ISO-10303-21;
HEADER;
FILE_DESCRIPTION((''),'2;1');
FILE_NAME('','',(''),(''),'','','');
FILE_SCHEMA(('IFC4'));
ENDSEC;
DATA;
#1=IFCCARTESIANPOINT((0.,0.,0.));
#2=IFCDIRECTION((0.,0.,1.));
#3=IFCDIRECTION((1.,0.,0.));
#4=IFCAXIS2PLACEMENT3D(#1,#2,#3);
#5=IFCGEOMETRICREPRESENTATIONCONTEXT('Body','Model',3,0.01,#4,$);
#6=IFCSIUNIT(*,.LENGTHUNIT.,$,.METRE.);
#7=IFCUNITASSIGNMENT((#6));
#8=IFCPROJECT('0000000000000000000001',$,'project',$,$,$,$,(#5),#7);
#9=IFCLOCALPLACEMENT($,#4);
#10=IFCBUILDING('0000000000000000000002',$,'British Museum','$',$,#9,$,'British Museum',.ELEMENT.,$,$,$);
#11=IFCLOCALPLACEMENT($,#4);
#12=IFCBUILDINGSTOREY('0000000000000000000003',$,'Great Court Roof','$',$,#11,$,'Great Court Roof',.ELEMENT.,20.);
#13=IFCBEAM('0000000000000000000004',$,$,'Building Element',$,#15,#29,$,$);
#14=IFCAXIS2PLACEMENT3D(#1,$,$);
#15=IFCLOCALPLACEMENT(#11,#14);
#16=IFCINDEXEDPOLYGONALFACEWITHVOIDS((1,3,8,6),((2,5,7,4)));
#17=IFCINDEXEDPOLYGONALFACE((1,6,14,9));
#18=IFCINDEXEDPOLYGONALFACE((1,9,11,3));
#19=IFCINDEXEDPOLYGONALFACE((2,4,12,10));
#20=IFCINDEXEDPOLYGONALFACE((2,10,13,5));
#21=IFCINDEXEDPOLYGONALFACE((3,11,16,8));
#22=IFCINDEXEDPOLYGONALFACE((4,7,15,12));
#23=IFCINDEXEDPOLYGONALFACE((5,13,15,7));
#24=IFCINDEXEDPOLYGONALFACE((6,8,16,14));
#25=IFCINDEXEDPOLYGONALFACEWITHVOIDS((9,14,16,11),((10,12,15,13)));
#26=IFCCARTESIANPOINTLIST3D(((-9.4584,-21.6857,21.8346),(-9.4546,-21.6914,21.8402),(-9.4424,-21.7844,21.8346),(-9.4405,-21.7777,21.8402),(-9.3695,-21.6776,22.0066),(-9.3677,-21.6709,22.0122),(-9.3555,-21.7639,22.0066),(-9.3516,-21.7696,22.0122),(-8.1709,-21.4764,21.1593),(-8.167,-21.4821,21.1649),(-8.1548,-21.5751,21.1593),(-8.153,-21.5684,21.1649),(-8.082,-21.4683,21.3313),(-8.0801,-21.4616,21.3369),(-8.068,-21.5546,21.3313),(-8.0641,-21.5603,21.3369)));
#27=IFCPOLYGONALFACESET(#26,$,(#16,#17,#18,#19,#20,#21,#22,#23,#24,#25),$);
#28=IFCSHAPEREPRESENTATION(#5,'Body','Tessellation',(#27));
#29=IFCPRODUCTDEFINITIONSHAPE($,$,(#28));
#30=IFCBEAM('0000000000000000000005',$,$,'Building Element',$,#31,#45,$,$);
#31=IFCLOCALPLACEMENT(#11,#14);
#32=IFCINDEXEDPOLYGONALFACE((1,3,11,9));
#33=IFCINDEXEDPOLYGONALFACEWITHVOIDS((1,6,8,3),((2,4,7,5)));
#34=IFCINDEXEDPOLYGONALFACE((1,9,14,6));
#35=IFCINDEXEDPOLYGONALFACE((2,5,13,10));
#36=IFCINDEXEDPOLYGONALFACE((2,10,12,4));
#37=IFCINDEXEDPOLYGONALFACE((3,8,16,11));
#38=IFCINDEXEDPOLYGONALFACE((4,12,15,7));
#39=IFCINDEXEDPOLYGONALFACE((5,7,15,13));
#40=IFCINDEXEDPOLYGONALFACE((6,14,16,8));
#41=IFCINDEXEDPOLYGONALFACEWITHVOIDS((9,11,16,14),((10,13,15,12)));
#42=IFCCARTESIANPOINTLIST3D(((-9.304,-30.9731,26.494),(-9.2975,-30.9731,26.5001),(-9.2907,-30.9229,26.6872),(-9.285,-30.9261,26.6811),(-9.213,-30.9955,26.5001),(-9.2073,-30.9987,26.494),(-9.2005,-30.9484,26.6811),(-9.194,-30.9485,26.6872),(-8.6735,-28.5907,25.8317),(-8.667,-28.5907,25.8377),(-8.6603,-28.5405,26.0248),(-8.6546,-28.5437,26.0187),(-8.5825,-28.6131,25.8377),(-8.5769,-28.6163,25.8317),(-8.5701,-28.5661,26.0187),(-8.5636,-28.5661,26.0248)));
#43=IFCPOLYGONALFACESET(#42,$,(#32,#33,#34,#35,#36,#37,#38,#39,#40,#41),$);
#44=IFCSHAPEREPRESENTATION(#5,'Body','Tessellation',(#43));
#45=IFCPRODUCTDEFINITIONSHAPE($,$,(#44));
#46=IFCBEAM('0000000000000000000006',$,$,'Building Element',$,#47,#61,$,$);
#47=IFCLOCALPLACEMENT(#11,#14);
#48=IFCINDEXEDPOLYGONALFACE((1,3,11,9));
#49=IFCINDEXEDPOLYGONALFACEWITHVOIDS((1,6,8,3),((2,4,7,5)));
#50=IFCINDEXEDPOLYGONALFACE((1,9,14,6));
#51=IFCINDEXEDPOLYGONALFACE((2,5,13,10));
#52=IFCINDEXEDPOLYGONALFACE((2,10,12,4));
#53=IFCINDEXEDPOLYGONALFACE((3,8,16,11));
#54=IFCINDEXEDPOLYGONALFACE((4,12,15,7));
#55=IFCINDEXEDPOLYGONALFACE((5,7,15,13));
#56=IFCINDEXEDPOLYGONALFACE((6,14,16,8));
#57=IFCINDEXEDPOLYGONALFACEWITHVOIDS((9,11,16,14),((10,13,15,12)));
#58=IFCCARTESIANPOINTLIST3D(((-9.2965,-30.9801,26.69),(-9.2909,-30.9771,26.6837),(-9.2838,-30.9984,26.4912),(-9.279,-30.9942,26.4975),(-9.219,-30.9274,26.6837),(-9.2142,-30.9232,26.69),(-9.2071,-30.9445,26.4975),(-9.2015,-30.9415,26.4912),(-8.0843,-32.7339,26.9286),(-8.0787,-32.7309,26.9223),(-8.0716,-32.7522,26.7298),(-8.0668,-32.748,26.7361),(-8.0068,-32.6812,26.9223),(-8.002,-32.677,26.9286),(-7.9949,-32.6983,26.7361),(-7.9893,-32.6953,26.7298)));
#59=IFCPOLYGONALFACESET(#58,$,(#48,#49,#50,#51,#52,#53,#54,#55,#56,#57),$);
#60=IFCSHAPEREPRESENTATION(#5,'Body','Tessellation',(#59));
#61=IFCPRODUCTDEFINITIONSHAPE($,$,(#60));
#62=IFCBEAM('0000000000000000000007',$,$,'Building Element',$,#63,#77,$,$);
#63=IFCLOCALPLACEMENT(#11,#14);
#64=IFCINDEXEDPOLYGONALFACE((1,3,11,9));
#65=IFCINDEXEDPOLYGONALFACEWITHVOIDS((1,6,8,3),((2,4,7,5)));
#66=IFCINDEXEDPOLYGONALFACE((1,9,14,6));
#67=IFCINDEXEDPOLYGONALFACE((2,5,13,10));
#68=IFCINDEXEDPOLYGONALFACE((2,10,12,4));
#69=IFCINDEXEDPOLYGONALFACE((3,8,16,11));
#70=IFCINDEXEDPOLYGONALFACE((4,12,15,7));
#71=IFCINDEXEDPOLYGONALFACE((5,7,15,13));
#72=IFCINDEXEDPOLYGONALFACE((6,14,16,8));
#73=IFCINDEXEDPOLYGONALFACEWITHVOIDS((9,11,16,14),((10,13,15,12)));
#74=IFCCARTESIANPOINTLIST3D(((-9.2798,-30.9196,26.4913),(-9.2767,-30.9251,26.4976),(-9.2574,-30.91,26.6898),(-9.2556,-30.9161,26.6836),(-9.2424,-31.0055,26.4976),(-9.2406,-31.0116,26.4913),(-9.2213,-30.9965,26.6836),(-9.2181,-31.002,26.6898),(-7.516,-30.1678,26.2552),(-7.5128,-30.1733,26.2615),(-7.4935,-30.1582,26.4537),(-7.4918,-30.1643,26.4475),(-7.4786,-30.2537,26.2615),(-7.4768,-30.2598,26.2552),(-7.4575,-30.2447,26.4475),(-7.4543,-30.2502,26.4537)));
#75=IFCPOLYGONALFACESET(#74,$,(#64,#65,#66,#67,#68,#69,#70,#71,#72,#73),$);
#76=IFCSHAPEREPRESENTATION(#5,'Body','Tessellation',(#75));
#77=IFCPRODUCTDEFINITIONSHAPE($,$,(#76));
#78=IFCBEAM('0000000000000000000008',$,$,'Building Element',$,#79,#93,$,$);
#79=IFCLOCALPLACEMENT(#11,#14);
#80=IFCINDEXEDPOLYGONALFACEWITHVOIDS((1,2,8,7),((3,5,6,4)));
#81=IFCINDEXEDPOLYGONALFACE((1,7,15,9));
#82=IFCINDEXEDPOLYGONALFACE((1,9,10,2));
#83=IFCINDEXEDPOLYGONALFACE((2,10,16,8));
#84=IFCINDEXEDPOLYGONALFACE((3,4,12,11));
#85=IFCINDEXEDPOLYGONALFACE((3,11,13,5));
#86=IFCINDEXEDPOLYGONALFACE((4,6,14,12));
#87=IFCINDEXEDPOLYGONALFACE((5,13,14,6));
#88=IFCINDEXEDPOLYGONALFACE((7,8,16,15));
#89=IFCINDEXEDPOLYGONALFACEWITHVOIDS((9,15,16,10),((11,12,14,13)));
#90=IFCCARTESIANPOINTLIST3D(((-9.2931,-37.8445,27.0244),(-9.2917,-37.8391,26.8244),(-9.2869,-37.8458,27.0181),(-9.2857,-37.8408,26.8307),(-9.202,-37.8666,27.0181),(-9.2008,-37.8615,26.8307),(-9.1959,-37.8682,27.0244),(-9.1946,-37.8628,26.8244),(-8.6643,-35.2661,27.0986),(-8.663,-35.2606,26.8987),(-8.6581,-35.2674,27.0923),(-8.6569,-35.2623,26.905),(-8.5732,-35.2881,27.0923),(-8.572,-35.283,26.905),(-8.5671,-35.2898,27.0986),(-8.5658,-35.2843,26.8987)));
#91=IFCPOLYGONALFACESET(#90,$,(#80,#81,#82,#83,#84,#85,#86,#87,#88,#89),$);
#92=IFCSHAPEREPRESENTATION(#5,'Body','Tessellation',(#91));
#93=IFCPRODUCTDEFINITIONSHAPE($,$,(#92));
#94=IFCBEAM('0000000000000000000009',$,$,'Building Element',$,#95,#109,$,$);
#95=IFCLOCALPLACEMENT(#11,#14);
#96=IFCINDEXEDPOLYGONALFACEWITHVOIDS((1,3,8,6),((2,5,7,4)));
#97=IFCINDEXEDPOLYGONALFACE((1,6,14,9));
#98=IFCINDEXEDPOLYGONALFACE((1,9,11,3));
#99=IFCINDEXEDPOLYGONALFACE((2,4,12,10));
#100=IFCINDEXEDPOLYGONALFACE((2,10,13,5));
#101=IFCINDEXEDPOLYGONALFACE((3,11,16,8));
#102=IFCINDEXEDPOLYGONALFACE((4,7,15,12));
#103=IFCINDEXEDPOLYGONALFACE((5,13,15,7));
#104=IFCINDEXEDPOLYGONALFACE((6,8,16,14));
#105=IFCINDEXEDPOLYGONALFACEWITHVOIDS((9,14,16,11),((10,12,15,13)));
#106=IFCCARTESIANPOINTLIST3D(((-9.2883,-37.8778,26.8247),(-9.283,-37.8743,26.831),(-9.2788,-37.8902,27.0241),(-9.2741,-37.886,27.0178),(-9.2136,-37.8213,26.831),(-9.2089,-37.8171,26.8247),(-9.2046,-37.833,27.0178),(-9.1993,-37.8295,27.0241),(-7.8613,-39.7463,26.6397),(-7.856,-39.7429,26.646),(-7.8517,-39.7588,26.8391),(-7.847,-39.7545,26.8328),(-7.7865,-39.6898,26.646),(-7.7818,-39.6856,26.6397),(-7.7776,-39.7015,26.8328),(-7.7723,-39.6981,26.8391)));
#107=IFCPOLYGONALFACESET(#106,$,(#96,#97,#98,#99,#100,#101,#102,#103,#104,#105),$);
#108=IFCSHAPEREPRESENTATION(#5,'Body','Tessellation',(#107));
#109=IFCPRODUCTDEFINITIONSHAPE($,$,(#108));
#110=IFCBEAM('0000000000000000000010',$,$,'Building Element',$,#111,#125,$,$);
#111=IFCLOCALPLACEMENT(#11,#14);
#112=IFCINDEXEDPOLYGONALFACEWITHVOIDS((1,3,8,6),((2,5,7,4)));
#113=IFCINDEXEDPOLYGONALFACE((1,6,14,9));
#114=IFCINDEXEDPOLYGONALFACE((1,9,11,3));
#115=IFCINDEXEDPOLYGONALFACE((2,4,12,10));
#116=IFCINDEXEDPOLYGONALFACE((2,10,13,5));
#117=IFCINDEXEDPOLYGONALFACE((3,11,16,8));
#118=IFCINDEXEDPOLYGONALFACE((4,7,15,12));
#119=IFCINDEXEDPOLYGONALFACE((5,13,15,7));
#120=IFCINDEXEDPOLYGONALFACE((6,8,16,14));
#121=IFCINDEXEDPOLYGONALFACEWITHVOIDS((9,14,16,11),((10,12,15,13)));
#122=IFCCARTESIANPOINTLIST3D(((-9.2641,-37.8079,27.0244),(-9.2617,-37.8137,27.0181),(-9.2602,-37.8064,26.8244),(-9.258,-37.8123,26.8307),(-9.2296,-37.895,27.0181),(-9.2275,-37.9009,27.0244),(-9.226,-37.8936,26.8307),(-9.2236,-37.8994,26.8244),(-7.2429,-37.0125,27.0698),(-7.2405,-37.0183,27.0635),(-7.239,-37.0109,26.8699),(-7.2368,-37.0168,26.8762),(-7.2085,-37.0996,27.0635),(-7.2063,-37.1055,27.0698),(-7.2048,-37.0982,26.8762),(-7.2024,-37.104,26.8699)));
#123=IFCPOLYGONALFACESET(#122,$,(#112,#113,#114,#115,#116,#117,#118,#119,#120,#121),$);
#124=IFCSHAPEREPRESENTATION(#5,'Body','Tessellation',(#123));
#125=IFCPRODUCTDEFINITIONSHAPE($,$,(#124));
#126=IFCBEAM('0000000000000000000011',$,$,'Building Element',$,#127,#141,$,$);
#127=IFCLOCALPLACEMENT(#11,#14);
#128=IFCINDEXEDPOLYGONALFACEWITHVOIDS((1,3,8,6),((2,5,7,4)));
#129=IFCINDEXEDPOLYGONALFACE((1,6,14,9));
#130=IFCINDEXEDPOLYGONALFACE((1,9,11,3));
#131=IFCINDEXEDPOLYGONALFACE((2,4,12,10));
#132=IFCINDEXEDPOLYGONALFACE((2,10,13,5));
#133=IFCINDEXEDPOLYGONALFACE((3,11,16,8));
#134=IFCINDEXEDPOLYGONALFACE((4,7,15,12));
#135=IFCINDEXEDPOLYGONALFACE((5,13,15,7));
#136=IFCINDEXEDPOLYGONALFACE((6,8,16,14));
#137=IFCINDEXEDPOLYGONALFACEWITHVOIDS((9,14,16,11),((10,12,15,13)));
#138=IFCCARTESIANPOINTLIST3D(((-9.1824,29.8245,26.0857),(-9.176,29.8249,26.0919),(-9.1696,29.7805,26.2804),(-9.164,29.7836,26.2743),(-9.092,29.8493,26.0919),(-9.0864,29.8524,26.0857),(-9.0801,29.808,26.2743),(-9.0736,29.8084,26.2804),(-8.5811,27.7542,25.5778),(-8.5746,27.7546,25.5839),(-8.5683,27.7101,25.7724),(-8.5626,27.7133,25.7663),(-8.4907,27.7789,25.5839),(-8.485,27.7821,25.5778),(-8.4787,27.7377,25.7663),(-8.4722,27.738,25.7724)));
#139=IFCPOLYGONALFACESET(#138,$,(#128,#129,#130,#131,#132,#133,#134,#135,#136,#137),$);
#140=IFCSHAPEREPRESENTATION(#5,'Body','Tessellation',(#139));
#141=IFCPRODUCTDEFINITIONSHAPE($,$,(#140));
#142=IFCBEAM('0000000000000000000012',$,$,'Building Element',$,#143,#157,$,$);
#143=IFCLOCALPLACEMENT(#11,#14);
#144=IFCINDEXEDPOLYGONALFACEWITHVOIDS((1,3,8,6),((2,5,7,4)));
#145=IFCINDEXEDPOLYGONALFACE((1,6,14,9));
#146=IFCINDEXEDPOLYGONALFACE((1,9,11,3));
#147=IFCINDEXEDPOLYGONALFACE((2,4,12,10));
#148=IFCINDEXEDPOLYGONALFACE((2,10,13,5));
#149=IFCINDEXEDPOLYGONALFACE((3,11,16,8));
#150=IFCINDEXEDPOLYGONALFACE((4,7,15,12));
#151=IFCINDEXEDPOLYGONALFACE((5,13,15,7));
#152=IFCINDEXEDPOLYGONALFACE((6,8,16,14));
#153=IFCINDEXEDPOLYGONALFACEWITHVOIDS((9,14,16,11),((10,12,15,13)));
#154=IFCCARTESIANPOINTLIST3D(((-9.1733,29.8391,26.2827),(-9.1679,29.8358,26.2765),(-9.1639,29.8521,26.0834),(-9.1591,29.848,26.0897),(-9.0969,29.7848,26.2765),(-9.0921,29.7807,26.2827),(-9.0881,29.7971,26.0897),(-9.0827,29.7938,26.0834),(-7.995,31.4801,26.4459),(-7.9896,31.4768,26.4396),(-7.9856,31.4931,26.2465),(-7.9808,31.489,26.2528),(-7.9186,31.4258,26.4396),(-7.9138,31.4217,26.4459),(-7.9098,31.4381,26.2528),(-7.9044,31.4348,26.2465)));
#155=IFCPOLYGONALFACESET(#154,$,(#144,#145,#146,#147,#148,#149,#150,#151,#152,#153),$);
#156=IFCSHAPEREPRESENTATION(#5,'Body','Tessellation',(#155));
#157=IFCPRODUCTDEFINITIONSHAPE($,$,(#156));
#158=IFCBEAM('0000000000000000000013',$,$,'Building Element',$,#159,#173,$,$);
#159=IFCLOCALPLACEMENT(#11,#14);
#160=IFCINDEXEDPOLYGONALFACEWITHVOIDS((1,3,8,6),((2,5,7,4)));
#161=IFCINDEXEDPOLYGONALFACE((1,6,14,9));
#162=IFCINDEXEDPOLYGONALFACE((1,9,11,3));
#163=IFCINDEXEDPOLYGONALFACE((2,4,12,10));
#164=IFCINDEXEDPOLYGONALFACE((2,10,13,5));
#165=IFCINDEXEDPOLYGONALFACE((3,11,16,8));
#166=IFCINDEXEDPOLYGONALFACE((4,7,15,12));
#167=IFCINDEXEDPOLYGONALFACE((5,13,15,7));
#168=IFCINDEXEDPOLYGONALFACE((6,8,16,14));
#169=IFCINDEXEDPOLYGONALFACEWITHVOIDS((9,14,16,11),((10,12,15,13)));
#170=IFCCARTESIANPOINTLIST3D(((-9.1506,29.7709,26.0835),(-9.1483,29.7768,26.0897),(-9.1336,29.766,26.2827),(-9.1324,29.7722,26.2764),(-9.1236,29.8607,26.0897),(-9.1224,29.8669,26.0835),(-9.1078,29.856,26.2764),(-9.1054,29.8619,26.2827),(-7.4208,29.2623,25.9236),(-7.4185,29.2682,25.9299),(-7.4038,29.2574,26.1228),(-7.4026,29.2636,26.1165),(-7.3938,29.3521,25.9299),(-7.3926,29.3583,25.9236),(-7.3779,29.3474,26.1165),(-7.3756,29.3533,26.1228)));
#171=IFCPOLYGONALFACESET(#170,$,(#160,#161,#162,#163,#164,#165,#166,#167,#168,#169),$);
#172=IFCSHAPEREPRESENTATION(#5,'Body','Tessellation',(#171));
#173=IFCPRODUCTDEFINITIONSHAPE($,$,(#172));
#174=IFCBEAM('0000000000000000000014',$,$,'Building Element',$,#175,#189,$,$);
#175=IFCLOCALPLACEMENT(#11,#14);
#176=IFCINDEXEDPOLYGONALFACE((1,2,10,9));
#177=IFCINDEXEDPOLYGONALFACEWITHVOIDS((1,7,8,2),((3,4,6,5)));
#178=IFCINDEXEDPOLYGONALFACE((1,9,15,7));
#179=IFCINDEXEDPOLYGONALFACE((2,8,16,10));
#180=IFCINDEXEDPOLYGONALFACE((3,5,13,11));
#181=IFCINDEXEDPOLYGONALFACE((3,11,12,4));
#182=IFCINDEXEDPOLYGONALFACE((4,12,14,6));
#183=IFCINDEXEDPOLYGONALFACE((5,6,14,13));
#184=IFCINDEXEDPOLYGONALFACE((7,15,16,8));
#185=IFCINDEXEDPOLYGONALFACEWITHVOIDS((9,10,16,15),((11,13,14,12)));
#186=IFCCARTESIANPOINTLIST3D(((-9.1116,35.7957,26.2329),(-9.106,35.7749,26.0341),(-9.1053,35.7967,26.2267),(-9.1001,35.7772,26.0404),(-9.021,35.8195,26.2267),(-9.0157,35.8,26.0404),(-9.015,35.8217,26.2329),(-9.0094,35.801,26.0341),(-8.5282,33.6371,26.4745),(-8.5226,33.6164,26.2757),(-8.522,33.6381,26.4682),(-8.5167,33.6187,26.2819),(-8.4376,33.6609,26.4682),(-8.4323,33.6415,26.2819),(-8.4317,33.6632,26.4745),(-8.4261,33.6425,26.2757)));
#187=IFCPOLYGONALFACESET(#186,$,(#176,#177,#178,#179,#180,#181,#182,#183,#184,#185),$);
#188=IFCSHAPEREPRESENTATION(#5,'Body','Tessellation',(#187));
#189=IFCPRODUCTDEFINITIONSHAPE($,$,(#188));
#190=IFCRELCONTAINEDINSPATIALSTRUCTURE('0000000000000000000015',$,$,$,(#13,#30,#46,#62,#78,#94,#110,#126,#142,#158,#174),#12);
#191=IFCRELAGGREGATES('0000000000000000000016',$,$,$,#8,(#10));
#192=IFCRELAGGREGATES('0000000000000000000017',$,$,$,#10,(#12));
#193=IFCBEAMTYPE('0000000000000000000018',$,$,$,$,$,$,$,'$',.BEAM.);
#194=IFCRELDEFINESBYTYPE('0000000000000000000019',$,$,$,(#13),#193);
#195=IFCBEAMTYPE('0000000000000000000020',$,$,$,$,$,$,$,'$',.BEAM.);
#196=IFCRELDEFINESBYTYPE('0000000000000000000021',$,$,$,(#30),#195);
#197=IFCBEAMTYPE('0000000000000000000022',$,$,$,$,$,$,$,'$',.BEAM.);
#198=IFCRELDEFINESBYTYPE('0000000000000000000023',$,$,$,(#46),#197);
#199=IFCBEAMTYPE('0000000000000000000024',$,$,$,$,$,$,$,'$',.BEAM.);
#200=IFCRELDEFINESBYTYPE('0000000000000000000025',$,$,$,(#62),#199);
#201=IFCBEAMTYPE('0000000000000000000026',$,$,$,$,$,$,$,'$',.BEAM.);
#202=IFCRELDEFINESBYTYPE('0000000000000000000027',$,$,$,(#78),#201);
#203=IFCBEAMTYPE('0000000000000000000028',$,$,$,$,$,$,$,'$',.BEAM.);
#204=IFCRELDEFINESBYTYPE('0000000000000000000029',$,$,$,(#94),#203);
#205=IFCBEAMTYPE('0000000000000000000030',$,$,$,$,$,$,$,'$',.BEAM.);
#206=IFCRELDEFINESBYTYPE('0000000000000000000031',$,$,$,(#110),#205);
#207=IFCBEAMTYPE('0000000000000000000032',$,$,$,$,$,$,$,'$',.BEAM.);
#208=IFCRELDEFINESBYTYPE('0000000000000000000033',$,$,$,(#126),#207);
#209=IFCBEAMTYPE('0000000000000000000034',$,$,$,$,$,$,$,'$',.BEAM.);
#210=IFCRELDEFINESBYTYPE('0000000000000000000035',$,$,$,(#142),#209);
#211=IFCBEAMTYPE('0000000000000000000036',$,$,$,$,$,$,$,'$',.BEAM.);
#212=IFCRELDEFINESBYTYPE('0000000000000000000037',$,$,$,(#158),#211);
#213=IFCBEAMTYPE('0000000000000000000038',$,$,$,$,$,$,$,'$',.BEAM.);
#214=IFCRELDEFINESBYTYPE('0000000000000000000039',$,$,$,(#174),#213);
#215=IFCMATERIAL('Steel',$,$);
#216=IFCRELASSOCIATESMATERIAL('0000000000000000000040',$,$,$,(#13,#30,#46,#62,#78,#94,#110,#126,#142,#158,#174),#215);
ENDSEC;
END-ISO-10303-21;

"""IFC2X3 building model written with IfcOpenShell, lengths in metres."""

from ifc_helpers import new_model, si_unit, frame, origin_with_axes, origin_2d, place, context, project, spatial, hollow_rectangle, extrude, material, type_object, element, save


model = new_model("IFC2X3")

# Units and contexts
model_context = context("Model", 3, precision=0.01, world=origin_with_axes(), identifier="Body")
ifc_project = project(units=[si_unit("LENGTHUNIT", "METRE")], contexts=[model_context])

# Building, storey
building_placement = place(None, origin_with_axes())
building = spatial("IfcBuilding", under=ifc_project, at=building_placement, Name="British Museum", Description="$", LongName="British Museum", CompositionType="ELEMENT")
storey_placement = place(None, origin_with_axes())
storey = spatial("IfcBuildingStorey", under=building, at=storey_placement, Name="Great Court Roof", Description="$", LongName="Great Court Roof", CompositionType="ELEMENT", Elevation=20.0)

# Beams
ifc_material = material(Name="Steel")
beam_type_1 = type_object("IfcBeamType", ElementType="$", PredefinedType="BEAM")
beam_1_placement = place(None, origin_with_axes())
element("IfcBeam", 1, at=beam_1_placement, inside=storey, type_object=beam_type_1, material=ifc_material, Description="Building Element", context=model_context, shape_type="SweptSolid", body=[
    extrude(hollow_rectangle(XDim=0.1, YDim=0.2, WallThickness=0.0063, InnerFilletRadius=-0.0063, OuterFilletRadius=0.0, at=origin_2d()), frame((-9.405, -21.7277, 21.9234), z_axis=(0.876559, 0.142505, -0.459714), x_axis=(-0.160466, 0.987041, 0.0)), (0.0, 0.0, 1.0), 1.4689),
])
beam_type_2 = type_object("IfcBeamType", ElementType="$", PredefinedType="BEAM")
beam_2_placement = place(None, origin_with_axes())
element("IfcBeam", 2, at=beam_2_placement, inside=storey, type_object=beam_type_2, material=ifc_material, Description="Building Element", context=model_context, shape_type="SweptSolid", body=[
    extrude(hollow_rectangle(XDim=0.1, YDim=0.2, WallThickness=0.0063, InnerFilletRadius=-0.0063, OuterFilletRadius=0.0, at=origin_2d()), frame((-9.249, -30.9608, 26.5906), z_axis=(0.247051, 0.933593, -0.259555), x_axis=(-0.966725, 0.255818, 0.0)), (0.0, 0.0, 1.0), 2.5518),
])
beam_type_3 = type_object("IfcBeamType", ElementType="$", PredefinedType="BEAM")
beam_3_placement = place(None, origin_with_axes())
element("IfcBeam", 3, at=beam_3_placement, inside=storey, type_object=beam_type_3, material=ifc_material, Description="Building Element", context=model_context, shape_type="SweptSolid", body=[
    extrude(hollow_rectangle(XDim=0.1, YDim=0.2, WallThickness=0.0063, InnerFilletRadius=-0.0063, OuterFilletRadius=0.0, at=origin_2d()), frame((-9.249, -30.9608, 26.5906), z_axis=(0.565057, -0.81752, 0.111223), x_axis=(0.822624, 0.568585, 0.0)), (0.0, 0.0, 1.0), 2.1453),
])
beam_type_4 = type_object("IfcBeamType", ElementType="$", PredefinedType="BEAM")
beam_4_placement = place(None, origin_with_axes())
element("IfcBeam", 4, at=beam_4_placement, inside=storey, type_object=beam_type_4, material=ifc_material, Description="Building Element", context=model_context, shape_type="SweptSolid", body=[
    extrude(hollow_rectangle(XDim=0.1, YDim=0.2, WallThickness=0.0063, InnerFilletRadius=-0.0063, OuterFilletRadius=0.0, at=origin_2d()), frame((-9.249, -30.9608, 26.5906), z_axis=(0.913029, 0.389157, -0.12221), x_axis=(-0.392096, 0.919924, 0.0)), (0.0, 0.0, 1.0), 1.9318),
])
beam_type_5 = type_object("IfcBeamType", ElementType="$", PredefinedType="BEAM")
beam_5_placement = place(None, origin_with_axes())
element("IfcBeam", 5, at=beam_5_placement, inside=storey, type_object=beam_type_5, material=ifc_material, Description="Building Element", context=model_context, shape_type="SweptSolid", body=[
    extrude(hollow_rectangle(XDim=0.1, YDim=0.2, WallThickness=0.0063, InnerFilletRadius=-0.0063, OuterFilletRadius=0.0, at=origin_2d()), frame((-9.2438, -37.8537, 26.9244), z_axis=(0.236825, 0.97115, 0.027949), x_axis=(-0.97153, 0.236918, 0.0)), (0.0, 0.0, 1.0), 2.655),
])
beam_type_6 = type_object("IfcBeamType", ElementType="$", PredefinedType="BEAM")
beam_6_placement = place(None, origin_with_axes())
element("IfcBeam", 6, at=beam_6_placement, inside=storey, type_object=beam_type_6, material=ifc_material, Description="Building Element", context=model_context, shape_type="SweptSolid", body=[
    extrude(hollow_rectangle(XDim=0.1, YDim=0.2, WallThickness=0.0063, InnerFilletRadius=-0.0063, OuterFilletRadius=0.0, at=origin_2d()), frame((-9.2438, -37.8537, 26.9244), z_axis=(0.605096, -0.792278, -0.078444), x_axis=(0.794727, 0.606967, 0.0)), (0.0, 0.0, 1.0), 2.3584),
])
beam_type_7 = type_object("IfcBeamType", ElementType="$", PredefinedType="BEAM")
beam_7_placement = place(None, origin_with_axes())
element("IfcBeam", 7, at=beam_7_placement, inside=storey, type_object=beam_type_7, material=ifc_material, Description="Building Element", context=model_context, shape_type="SweptSolid", body=[
    extrude(hollow_rectangle(XDim=0.1, YDim=0.2, WallThickness=0.0063, InnerFilletRadius=-0.0063, OuterFilletRadius=0.0, at=origin_2d()), frame((-9.2438, -37.8537, 26.9244), z_axis=(0.930327, 0.366133, 0.020926), x_axis=(-0.366214, 0.930531, 0.0)), (0.0, 0.0, 1.0), 2.1725),
])
beam_type_8 = type_object("IfcBeamType", ElementType="$", PredefinedType="BEAM")
beam_8_placement = place(None, origin_with_axes())
element("IfcBeam", 8, at=beam_8_placement, inside=storey, type_object=beam_type_8, material=ifc_material, Description="Building Element", context=model_context, shape_type="SweptSolid", body=[
    extrude(hollow_rectangle(XDim=0.1, YDim=0.2, WallThickness=0.0063, InnerFilletRadius=-0.0063, OuterFilletRadius=0.0, at=origin_2d()), frame((-9.128, 29.8164, 26.1831), z_axis=(0.271505, -0.934713, -0.229341), x_axis=(0.960309, 0.27894, 0.0)), (0.0, 0.0, 1.0), 2.2149),
])
beam_type_9 = type_object("IfcBeamType", ElementType="$", PredefinedType="BEAM")
beam_9_placement = place(None, origin_with_axes())
element("IfcBeam", 9, at=beam_9_placement, inside=storey, type_object=beam_type_9, material=ifc_material, Description="Building Element", context=model_context, shape_type="SweptSolid", body=[
    extrude(hollow_rectangle(XDim=0.1, YDim=0.2, WallThickness=0.0063, InnerFilletRadius=-0.0063, OuterFilletRadius=0.0, at=origin_2d()), frame((-9.128, 29.8164, 26.1831), z_axis=(0.581374, 0.809646, 0.080485), x_axis=(-0.812281, 0.583267, 0.0)), (0.0, 0.0, 1.0), 2.0268),
])
beam_type_10 = type_object("IfcBeamType", ElementType="$", PredefinedType="BEAM")
beam_10_placement = place(None, origin_with_axes())
element("IfcBeam", 10, at=beam_10_placement, inside=storey, type_object=beam_type_10, material=ifc_material, Description="Building Element", context=model_context, shape_type="SweptSolid", body=[
    extrude(hollow_rectangle(XDim=0.1, YDim=0.2, WallThickness=0.0063, InnerFilletRadius=-0.0063, OuterFilletRadius=0.0, at=origin_2d()), frame((-9.128, 29.8164, 26.1831), z_axis=(0.95564, -0.280982, -0.088329), x_axis=(0.282084, 0.95939, 0.0)), (0.0, 0.0, 1.0), 1.8101),
])
beam_type_11 = type_object("IfcBeamType", ElementType="$", PredefinedType="BEAM")
beam_11_placement = place(None, origin_with_axes())
element("IfcBeam", 11, at=beam_11_placement, inside=storey, type_object=beam_type_11, material=ifc_material, Description="Building Element", context=model_context, shape_type="SweptSolid", body=[
    extrude(hollow_rectangle(XDim=0.1, YDim=0.2, WallThickness=0.0063, InnerFilletRadius=-0.0063, OuterFilletRadius=0.0, at=origin_2d()), frame((-9.0605, 35.7983, 26.1335), z_axis=(0.25939, -0.959782, 0.107405), x_axis=(0.965366, 0.260899, 0.0)), (0.0, 0.0, 1.0), 2.249),
])

save(model, "model.ifc")
